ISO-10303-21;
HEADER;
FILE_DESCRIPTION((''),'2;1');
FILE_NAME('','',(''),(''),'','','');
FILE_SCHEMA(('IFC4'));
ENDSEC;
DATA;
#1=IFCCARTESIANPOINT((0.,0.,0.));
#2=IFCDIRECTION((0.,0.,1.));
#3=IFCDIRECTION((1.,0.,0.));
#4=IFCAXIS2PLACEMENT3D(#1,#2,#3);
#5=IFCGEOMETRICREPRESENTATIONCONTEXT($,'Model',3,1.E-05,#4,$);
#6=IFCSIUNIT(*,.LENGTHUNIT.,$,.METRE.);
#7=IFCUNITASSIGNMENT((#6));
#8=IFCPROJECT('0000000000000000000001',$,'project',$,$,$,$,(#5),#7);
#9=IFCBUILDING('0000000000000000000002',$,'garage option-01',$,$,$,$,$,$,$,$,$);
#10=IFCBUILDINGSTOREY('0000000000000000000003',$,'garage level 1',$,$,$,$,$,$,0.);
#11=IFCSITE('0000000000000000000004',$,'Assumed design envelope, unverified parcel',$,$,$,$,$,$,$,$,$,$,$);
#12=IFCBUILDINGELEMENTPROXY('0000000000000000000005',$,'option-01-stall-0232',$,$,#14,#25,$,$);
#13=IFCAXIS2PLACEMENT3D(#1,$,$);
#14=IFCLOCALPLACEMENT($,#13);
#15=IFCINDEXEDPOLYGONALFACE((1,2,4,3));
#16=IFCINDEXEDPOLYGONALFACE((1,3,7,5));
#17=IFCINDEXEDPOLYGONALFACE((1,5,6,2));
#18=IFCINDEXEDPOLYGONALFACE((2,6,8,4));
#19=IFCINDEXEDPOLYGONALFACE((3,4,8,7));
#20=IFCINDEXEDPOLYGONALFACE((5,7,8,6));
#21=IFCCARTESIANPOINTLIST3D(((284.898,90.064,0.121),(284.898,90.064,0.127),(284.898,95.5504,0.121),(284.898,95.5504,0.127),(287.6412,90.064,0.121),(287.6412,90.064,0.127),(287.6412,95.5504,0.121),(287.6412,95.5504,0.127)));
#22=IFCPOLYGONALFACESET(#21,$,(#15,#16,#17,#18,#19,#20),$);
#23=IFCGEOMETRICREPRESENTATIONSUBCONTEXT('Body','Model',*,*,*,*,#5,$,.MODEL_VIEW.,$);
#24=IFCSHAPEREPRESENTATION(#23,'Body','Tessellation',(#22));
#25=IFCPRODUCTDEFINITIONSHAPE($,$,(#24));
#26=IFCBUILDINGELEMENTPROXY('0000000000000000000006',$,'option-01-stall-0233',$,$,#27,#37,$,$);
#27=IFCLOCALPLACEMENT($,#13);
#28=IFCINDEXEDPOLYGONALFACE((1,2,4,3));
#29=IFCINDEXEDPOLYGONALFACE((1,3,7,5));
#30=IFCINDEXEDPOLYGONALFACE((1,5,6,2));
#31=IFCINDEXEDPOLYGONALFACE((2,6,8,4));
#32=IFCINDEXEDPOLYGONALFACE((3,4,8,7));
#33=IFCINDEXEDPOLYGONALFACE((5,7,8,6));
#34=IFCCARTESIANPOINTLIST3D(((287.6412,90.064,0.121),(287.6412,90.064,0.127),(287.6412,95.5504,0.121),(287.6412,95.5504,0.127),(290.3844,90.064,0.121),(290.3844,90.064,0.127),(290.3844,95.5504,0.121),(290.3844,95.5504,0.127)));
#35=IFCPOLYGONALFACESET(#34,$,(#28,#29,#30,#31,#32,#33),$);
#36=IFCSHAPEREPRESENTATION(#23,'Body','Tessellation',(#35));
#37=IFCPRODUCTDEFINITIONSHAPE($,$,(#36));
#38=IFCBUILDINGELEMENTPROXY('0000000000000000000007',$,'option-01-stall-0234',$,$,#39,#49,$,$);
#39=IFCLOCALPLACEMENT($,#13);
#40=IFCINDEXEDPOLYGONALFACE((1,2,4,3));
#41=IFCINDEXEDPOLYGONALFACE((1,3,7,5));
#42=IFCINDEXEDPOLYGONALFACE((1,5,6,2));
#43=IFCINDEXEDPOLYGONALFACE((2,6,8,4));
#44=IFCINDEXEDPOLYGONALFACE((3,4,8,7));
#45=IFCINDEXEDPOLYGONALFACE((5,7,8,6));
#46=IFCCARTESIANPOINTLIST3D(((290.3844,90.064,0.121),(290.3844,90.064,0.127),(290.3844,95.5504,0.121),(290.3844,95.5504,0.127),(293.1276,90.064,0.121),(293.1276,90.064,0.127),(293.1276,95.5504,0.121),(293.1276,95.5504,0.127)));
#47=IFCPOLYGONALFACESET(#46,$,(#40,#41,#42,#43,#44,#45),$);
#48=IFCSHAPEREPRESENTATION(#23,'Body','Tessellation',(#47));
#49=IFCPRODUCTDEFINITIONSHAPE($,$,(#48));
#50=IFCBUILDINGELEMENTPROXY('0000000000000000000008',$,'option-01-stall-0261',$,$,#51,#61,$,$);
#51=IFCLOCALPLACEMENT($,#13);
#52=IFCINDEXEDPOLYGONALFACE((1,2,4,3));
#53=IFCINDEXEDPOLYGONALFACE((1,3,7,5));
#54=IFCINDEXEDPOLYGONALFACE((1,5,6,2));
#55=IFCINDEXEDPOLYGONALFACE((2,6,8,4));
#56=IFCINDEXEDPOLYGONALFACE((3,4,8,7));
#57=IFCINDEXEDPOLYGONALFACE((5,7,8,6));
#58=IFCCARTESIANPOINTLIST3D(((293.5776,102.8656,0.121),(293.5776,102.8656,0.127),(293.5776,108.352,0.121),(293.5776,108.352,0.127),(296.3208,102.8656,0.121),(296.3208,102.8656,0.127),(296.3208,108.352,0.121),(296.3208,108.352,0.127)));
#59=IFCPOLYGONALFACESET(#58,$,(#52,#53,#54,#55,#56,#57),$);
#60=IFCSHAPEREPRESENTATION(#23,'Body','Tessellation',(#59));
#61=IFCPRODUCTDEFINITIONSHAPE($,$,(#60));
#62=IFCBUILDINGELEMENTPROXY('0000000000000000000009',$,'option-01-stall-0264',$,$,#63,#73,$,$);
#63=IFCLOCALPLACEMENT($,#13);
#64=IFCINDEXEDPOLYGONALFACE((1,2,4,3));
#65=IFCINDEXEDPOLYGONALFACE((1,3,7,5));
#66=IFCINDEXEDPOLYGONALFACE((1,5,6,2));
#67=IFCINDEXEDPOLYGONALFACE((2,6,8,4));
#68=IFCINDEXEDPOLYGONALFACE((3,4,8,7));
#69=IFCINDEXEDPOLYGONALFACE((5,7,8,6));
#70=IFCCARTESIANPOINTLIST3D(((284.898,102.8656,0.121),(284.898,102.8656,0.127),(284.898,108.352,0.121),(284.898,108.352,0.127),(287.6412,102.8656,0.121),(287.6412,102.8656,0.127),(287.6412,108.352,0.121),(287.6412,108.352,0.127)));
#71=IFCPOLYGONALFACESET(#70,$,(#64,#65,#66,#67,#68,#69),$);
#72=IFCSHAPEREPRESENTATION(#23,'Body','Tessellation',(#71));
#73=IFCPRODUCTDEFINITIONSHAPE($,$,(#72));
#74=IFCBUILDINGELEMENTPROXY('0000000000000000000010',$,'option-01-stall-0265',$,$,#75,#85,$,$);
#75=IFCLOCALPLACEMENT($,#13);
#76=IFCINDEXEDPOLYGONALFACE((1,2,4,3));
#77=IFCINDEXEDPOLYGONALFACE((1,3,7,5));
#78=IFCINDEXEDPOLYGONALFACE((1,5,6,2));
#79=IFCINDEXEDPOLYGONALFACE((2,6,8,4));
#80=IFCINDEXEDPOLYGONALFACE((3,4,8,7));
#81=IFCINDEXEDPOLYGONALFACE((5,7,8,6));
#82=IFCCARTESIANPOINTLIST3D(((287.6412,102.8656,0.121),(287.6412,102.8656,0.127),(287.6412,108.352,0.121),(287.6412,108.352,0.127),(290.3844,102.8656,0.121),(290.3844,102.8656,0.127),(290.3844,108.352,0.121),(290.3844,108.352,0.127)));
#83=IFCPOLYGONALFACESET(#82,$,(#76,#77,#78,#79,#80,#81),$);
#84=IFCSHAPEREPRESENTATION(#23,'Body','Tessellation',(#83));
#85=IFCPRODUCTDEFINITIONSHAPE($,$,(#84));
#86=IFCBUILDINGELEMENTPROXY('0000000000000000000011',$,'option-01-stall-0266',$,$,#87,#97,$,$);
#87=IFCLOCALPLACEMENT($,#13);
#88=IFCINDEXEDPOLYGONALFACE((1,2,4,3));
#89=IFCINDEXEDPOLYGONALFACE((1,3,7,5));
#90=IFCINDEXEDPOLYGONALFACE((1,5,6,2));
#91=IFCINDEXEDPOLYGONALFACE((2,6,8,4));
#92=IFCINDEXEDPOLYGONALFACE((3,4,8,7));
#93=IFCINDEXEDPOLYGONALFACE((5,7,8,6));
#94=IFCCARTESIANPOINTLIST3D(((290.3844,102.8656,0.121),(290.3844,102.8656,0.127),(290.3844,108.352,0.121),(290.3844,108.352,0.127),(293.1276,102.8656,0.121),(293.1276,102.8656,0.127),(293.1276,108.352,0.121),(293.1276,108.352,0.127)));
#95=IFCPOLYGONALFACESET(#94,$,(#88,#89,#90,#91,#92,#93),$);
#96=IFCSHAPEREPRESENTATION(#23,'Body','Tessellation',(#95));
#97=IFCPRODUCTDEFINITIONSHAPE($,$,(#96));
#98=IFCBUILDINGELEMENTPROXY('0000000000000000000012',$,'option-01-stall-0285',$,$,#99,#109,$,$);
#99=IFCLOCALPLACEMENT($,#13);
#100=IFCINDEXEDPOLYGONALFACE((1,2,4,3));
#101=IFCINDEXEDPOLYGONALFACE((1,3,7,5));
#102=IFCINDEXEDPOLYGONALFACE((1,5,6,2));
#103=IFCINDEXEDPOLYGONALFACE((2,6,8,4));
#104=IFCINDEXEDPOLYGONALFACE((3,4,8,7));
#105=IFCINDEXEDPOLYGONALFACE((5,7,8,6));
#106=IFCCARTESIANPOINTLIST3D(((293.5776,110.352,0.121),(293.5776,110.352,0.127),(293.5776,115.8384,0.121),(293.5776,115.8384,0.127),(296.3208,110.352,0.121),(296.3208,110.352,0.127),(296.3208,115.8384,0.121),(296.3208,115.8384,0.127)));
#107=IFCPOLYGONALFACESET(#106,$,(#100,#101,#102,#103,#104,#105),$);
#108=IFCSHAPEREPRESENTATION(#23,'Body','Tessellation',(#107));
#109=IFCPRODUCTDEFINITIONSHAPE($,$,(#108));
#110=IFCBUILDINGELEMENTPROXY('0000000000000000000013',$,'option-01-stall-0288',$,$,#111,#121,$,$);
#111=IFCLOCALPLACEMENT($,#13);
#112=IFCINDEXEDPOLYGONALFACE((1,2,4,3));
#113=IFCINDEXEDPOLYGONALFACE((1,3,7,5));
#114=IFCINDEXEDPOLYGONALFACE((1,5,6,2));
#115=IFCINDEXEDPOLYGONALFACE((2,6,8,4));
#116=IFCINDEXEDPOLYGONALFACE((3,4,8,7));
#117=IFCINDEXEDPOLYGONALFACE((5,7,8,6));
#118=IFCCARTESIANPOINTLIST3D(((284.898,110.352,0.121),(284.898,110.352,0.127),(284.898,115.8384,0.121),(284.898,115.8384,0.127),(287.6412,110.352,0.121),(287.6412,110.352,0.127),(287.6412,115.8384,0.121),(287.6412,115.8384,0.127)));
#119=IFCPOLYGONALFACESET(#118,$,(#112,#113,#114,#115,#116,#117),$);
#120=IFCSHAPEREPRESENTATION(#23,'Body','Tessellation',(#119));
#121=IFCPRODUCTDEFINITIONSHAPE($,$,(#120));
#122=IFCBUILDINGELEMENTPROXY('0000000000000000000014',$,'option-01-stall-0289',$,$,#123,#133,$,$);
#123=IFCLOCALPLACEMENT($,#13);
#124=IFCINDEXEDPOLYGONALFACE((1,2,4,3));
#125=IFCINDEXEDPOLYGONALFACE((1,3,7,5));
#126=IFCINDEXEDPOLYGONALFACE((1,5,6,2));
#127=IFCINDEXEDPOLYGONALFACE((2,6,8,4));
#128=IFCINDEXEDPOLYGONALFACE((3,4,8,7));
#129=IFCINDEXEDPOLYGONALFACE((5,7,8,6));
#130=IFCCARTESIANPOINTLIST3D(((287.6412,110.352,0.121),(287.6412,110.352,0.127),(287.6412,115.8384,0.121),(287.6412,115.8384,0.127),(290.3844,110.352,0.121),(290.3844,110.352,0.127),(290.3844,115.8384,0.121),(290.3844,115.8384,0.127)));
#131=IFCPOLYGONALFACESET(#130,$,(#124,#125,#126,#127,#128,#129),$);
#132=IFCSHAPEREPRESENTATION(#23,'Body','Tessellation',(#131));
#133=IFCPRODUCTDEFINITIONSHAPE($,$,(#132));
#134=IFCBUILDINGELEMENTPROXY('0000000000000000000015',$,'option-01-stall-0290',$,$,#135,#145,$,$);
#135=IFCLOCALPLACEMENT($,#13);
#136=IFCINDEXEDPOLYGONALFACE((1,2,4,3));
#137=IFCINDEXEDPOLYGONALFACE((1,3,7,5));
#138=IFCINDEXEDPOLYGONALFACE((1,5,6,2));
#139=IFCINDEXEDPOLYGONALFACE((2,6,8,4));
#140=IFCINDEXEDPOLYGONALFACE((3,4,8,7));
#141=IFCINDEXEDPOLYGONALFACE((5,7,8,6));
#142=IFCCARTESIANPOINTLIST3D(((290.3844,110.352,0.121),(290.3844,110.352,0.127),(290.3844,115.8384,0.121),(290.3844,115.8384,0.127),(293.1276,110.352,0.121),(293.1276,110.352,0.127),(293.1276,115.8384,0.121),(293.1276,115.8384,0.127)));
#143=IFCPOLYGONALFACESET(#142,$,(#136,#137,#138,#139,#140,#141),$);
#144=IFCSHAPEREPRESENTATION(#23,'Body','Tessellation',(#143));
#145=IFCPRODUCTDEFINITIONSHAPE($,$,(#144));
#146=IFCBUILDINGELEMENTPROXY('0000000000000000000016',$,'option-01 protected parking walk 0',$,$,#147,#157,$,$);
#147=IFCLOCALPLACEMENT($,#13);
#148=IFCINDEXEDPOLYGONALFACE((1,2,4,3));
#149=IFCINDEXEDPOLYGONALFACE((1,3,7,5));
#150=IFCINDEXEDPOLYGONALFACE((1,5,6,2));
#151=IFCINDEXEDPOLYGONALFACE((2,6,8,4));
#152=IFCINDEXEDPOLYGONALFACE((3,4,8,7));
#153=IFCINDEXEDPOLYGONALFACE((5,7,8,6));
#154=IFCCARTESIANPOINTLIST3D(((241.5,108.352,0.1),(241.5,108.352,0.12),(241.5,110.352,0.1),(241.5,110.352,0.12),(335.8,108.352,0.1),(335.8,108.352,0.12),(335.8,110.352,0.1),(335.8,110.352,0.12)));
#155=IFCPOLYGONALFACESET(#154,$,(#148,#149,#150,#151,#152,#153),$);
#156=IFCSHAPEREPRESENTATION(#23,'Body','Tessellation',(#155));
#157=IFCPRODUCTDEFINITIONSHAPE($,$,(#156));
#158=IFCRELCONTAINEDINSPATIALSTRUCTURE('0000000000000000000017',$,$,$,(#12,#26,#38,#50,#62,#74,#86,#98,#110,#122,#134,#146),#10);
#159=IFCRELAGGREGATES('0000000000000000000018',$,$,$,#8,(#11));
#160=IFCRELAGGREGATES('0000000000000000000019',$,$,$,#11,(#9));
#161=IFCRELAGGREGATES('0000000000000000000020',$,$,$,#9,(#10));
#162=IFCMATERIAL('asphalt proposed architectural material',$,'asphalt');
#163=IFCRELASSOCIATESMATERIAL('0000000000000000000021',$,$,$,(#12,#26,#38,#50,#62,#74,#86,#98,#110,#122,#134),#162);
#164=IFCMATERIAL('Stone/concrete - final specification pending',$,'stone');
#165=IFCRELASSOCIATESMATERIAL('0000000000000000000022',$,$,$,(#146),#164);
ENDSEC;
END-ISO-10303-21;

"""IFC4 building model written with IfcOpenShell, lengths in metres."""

from ifc_helpers import new_model, si_unit, frame, origin_with_axes, place, context, subcontext, project, spatial, rectangle, extrude, material, element, save


model = new_model("IFC4")

# Units and contexts
model_context = context("Model", 3, precision=1e-05, world=origin_with_axes())
body_context = subcontext(model_context, "Body", "Model", "MODEL_VIEW")
ifc_project = project(units=[si_unit("LENGTHUNIT", "METRE")], contexts=[model_context])

# Site, building, storey
site = spatial("IfcSite", under=ifc_project, Name="Assumed design envelope, unverified parcel")
building = spatial("IfcBuilding", under=site, Name="garage option-01")
storey = spatial("IfcBuildingStorey", under=building, Name="garage level 1", Elevation=0.0)

# Building element proxies
ifc_material_1 = material(Name="asphalt proposed architectural material", Category="asphalt")
for number, where, z_axis, x_axis, name in (
    (1, (286.2696, 92.8072, 0.121), (0.0, 0.0, 1.0), (1.0, 0.0, 0.0), "option-01-stall-0232"),
    (2, (289.0128, 92.8072, 0.121), (0.0, 0.0, 1.0), (1.0, 0.0, 0.0), "option-01-stall-0233"),
    (3, (291.756, 92.8072, 0.121), (0.0, 0.0, 1.0), (1.0, 0.0, 0.0), "option-01-stall-0234"),
    (4, (294.9492, 105.6088, 0.121), (0.0, 0.0, 1.0), (1.0, 0.0, 0.0), "option-01-stall-0261"),
    (5, (286.2696, 105.6088, 0.121), (0.0, 0.0, 1.0), (1.0, 0.0, 0.0), "option-01-stall-0264"),
    (6, (289.0128, 105.6088, 0.121), (0.0, 0.0, 1.0), (1.0, 0.0, 0.0), "option-01-stall-0265"),
    (7, (291.756, 105.6088, 0.121), (0.0, 0.0, 1.0), (1.0, 0.0, 0.0), "option-01-stall-0266"),
    (8, (294.9492, 113.0952, 0.121), (0.0, 0.0, 1.0), (1.0, 0.0, 0.0), "option-01-stall-0285"),
    (9, (286.2696, 113.0952, 0.121), (0.0, 0.0, 1.0), (1.0, 0.0, 0.0), "option-01-stall-0288"),
    (10, (289.0128, 113.0952, 0.121), (0.0, 0.0, 1.0), (1.0, 0.0, 0.0), "option-01-stall-0289"),
    (11, (291.756, 113.0952, 0.121), (0.0, 0.0, 1.0), (1.0, 0.0, 0.0), "option-01-stall-0290"),
):
    element("IfcBuildingElementProxy", number, at=place(None, frame(where, z_axis=z_axis, x_axis=x_axis)), inside=storey, material=ifc_material_1, Name=name, context=body_context, shape_type="SweptSolid", body=[
        extrude(rectangle(XDim=2.7432, YDim=5.4864), origin_with_axes(), (0.0, 0.0, 1.0), 0.006),
    ])
ifc_material_2 = material(Name="Stone/concrete - final specification pending", Category="stone")
proxy_placement = place(None, frame((288.65, 109.352, 0.1), z_axis=(0.0, 0.0, 1.0), x_axis=(1.0, 0.0, 0.0)))
element("IfcBuildingElementProxy", 12, at=proxy_placement, inside=storey, material=ifc_material_2, Name="option-01 protected parking walk 0", context=body_context, shape_type="SweptSolid", body=[
    extrude(rectangle(XDim=94.3, YDim=2.0), origin_with_axes(), (0.0, 0.0, 1.0), 0.02),
])

save(model, "model.ifc")
